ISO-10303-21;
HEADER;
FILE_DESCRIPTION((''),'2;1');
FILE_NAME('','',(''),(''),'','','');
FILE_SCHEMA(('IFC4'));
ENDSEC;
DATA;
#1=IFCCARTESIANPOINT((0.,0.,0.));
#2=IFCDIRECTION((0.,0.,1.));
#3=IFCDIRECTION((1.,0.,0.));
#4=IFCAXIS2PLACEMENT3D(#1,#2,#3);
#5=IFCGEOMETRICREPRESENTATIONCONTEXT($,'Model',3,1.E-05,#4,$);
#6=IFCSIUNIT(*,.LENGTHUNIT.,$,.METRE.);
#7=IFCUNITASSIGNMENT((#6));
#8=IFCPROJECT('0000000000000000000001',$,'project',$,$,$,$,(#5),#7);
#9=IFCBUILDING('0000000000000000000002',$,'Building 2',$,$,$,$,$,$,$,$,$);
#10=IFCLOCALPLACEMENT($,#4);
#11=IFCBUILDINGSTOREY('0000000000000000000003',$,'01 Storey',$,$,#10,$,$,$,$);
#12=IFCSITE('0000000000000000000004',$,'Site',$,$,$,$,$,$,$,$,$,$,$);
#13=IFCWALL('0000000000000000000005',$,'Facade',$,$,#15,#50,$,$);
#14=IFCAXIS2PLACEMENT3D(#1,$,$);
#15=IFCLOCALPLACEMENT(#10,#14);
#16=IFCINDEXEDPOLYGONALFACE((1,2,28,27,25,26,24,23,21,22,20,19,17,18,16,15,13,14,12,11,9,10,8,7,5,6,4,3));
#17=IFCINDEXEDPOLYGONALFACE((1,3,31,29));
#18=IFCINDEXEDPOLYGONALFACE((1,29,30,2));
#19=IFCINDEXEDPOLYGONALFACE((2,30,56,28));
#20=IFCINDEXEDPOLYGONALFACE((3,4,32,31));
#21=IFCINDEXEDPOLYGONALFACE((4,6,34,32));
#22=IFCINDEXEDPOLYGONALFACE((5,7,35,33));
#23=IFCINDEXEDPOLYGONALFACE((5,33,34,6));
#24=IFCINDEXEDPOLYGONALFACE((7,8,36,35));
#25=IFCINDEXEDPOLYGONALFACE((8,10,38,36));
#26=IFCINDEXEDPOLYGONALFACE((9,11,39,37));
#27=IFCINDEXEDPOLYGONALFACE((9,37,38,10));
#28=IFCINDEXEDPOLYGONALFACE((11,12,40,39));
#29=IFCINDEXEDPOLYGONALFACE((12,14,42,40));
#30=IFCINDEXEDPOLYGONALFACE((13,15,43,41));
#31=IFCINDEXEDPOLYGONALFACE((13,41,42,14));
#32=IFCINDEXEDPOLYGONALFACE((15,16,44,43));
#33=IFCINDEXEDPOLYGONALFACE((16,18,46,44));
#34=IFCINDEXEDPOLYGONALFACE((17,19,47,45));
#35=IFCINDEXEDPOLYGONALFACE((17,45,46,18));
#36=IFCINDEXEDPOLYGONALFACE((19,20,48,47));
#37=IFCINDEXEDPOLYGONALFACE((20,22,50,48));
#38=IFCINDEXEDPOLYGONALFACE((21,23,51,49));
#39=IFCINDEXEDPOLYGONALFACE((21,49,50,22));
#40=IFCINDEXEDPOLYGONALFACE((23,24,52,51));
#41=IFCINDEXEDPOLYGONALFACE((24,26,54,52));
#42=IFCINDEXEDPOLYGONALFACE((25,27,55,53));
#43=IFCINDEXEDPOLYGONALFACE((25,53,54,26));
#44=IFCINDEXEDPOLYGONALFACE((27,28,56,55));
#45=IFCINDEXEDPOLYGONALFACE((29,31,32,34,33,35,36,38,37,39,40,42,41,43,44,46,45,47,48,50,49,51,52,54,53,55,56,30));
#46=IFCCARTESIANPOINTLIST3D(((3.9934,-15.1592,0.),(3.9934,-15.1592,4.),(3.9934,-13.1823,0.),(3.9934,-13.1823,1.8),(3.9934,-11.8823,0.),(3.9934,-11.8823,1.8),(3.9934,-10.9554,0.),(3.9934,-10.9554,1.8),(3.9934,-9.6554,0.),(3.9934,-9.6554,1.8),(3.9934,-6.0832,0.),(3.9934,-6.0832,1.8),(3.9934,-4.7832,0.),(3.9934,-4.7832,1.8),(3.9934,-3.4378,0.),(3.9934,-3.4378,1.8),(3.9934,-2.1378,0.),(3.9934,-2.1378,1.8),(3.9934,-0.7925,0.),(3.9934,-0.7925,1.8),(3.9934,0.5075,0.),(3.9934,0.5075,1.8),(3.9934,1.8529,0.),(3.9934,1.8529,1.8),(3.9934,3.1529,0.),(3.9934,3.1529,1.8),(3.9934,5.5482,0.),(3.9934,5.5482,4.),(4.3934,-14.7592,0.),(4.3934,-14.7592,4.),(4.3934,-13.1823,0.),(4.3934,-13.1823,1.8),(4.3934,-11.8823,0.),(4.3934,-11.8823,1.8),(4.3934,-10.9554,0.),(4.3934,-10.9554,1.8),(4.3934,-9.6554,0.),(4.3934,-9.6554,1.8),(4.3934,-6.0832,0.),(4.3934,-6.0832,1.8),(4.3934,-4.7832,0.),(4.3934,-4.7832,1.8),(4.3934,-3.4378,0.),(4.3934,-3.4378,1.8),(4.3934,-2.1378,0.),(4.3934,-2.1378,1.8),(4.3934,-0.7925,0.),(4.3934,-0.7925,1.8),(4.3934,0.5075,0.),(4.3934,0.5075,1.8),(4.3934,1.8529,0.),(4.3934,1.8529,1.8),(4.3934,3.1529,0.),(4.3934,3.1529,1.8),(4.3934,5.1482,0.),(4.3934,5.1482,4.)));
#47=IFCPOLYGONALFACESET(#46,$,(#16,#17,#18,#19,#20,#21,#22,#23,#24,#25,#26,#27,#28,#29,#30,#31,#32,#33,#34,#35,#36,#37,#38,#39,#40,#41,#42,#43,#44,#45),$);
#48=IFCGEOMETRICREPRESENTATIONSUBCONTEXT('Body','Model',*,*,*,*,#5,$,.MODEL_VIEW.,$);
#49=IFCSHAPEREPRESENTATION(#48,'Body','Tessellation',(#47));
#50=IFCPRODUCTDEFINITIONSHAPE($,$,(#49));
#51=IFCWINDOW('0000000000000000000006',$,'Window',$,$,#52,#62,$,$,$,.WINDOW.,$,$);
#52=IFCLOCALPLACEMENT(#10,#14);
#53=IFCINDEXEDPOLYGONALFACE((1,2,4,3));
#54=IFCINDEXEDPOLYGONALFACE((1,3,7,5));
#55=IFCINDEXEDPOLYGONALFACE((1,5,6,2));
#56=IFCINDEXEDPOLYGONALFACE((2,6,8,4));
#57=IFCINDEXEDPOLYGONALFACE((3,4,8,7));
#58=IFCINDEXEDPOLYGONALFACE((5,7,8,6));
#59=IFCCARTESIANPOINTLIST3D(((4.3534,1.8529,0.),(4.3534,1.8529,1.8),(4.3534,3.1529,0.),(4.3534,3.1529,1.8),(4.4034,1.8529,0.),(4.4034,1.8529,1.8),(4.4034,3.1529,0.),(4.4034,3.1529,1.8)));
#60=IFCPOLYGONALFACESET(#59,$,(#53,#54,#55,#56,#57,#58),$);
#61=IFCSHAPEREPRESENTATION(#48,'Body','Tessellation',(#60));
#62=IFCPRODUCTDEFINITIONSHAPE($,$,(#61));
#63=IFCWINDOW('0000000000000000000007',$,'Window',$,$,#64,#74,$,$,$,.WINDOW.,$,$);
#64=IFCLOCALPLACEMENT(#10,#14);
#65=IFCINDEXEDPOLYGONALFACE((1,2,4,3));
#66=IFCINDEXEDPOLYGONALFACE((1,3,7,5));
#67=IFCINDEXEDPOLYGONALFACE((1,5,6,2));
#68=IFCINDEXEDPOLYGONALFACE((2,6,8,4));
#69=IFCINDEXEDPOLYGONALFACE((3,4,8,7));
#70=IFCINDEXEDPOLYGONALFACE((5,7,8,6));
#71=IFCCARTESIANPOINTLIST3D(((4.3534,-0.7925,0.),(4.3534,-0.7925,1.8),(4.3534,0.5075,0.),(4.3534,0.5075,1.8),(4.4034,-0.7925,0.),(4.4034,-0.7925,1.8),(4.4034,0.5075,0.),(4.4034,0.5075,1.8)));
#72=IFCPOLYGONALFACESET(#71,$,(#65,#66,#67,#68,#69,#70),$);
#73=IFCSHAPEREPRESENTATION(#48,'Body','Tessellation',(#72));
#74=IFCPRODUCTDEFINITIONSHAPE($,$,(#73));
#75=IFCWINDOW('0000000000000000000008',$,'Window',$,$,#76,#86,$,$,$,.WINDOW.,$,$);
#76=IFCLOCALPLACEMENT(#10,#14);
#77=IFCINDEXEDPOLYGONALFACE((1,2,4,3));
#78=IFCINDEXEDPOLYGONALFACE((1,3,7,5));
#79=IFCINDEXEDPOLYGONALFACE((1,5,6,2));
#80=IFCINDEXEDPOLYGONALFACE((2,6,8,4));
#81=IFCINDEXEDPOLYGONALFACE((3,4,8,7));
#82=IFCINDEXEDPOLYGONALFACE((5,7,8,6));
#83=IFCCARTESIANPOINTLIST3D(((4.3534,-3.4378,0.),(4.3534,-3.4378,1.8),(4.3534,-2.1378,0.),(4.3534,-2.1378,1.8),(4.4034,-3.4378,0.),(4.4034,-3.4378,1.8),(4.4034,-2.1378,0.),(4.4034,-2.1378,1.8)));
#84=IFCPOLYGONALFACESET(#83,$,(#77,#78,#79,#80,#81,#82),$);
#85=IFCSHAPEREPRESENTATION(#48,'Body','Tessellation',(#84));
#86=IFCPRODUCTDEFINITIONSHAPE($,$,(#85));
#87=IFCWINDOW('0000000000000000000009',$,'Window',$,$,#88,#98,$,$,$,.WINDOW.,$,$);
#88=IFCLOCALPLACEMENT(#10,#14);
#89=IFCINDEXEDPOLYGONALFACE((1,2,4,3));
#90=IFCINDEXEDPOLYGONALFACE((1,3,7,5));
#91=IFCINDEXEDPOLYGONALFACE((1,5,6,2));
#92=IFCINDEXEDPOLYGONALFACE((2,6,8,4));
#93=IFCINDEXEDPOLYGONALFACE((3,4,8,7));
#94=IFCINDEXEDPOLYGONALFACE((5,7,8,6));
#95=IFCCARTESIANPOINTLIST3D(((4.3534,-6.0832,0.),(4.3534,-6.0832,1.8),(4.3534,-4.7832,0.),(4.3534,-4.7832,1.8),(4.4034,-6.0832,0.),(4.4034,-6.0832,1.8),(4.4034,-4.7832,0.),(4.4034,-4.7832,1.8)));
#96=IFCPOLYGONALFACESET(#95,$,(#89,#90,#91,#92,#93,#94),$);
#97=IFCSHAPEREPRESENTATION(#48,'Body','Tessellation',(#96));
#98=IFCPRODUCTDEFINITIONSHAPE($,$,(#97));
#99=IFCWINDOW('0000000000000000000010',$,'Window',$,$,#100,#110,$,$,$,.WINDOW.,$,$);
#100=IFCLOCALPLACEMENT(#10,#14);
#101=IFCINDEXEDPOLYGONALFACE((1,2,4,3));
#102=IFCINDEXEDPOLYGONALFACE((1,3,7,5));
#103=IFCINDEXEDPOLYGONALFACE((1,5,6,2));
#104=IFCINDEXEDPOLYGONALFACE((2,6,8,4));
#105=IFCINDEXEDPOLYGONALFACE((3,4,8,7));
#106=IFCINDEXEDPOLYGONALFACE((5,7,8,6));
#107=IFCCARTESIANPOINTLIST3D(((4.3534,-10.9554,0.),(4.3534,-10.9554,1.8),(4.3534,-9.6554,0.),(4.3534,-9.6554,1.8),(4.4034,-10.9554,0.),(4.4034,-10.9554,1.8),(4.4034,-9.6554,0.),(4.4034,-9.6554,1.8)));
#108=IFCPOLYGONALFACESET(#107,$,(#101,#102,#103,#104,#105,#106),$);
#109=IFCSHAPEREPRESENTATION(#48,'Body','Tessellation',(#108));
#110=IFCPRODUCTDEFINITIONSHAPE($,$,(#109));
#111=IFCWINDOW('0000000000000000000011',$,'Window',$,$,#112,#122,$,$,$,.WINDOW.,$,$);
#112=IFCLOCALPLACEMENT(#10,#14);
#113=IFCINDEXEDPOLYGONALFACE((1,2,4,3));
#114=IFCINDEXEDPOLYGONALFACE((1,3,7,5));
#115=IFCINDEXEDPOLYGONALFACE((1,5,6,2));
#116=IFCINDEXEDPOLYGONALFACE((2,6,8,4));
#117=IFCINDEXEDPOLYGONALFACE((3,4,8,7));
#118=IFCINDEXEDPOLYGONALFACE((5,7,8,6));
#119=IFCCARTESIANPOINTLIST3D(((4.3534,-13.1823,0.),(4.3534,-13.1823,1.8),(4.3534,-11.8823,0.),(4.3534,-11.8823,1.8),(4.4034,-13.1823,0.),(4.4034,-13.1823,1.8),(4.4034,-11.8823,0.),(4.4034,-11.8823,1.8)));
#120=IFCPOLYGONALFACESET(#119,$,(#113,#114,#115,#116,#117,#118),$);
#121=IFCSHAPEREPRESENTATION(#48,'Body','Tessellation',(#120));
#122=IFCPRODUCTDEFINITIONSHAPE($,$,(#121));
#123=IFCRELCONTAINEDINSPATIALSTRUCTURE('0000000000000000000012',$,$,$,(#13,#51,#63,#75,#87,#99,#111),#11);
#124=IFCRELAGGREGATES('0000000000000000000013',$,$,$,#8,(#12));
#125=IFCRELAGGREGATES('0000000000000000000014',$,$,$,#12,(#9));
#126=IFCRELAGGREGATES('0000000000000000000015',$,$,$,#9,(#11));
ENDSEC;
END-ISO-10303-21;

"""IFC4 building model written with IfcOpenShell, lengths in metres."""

from ifc_helpers import new_model, si_unit, origin_with_axes, place, context, subcontext, project, spatial, line, indexed_curve, outline, extrude, element, fill, save


model = new_model("IFC4")

# Units and contexts
model_context = context("Model", 3, precision=1e-05, world=origin_with_axes())
body_context = subcontext(model_context, "Body", "Model", "MODEL_VIEW")
ifc_project = project(units=[si_unit("LENGTHUNIT", "METRE")], contexts=[model_context])

# Site, building, storey
site = spatial("IfcSite", under=ifc_project, Name="Site")
building = spatial("IfcBuilding", under=site, Name="Building 2")
storey_placement = place(None, origin_with_axes())
storey = spatial("IfcBuildingStorey", under=building, at=storey_placement, Name="01 Storey")

# Wall, openings, windows
wall_1_placement = place(storey_placement, origin_with_axes())
wall_1 = element("IfcWall", 1, at=wall_1_placement, inside=storey, Name="Facade", context=body_context, shape_type="SweptSolid", body=[
    extrude(outline(indexed_curve([(4.3934, 5.1482), (4.3934, -14.7592), (3.9934, -15.1592), (3.9934, 5.5482)], segments=[line(1, 2), line(2, 3), line(3, 4)])), origin_with_axes(), (0.0, 0.0, 1.0), 4.0),
])
opening_1_placement = place(wall_1_placement, origin_with_axes())
opening_1 = element("IfcOpeningElement", 2, at=opening_1_placement, cuts=wall_1, context=body_context, shape_type="SweptSolid", body=[
    extrude(outline(indexed_curve([(3.9534, 3.1529), (4.4534, 3.1529), (4.4534, 1.8529), (3.9534, 1.8529)], segments=[line(1, 2), line(2, 3), line(3, 4)])), origin_with_axes(), (0.0, 0.0, 1.0), 1.8),
])
opening_2_placement = place(wall_1_placement, origin_with_axes())
opening_2 = element("IfcOpeningElement", 3, at=opening_2_placement, cuts=wall_1, context=body_context, shape_type="SweptSolid", body=[
    extrude(outline(indexed_curve([(3.9534, 0.5075), (4.4534, 0.5075), (4.4534, -0.7925), (3.9534, -0.7925)], segments=[line(1, 2), line(2, 3), line(3, 4)])), origin_with_axes(), (0.0, 0.0, 1.0), 1.8),
])
opening_3_placement = place(wall_1_placement, origin_with_axes())
opening_3 = element("IfcOpeningElement", 4, at=opening_3_placement, cuts=wall_1, context=body_context, shape_type="SweptSolid", body=[
    extrude(outline(indexed_curve([(3.9534, -2.1378), (4.4534, -2.1378), (4.4534, -3.4378), (3.9534, -3.4378)], segments=[line(1, 2), line(2, 3), line(3, 4)])), origin_with_axes(), (0.0, 0.0, 1.0), 1.8),
])
opening_4_placement = place(wall_1_placement, origin_with_axes())
opening_4 = element("IfcOpeningElement", 5, at=opening_4_placement, cuts=wall_1, context=body_context, shape_type="SweptSolid", body=[
    extrude(outline(indexed_curve([(3.9534, -4.7832), (4.4534, -4.7832), (4.4534, -6.0832), (3.9534, -6.0832)], segments=[line(1, 2), line(2, 3), line(3, 4)])), origin_with_axes(), (0.0, 0.0, 1.0), 1.8),
])
opening_5_placement = place(wall_1_placement, origin_with_axes())
opening_5 = element("IfcOpeningElement", 6, at=opening_5_placement, cuts=wall_1, context=body_context, shape_type="SweptSolid", body=[
    extrude(outline(indexed_curve([(3.9534, -9.6554), (4.4534, -9.6554), (4.4534, -10.9554), (3.9534, -10.9554)], segments=[line(1, 2), line(2, 3), line(3, 4)])), origin_with_axes(), (0.0, 0.0, 1.0), 1.8),
])
opening_6_placement = place(wall_1_placement, origin_with_axes())
opening_6 = element("IfcOpeningElement", 7, at=opening_6_placement, cuts=wall_1, context=body_context, shape_type="SweptSolid", body=[
    extrude(outline(indexed_curve([(3.9534, -11.8823), (4.4534, -11.8823), (4.4534, -13.1823), (3.9534, -13.1823)], segments=[line(1, 2), line(2, 3), line(3, 4)])), origin_with_axes(), (0.0, 0.0, 1.0), 1.8),
])
window_1_placement = place(storey_placement, origin_with_axes())
window_1 = element("IfcWindow", 8, at=window_1_placement, inside=storey, Name="Window", PredefinedType="WINDOW", context=body_context, shape_type="SweptSolid", body=[
    extrude(outline(indexed_curve([(4.3534, 3.1529), (4.4034, 3.1529), (4.4034, 1.8529), (4.3534, 1.8529)], segments=[line(1, 2), line(2, 3), line(3, 4)])), origin_with_axes(), (0.0, 0.0, 1.0), 1.8),
])
fill(opening_1, window_1)
window_2_placement = place(storey_placement, origin_with_axes())
window_2 = element("IfcWindow", 9, at=window_2_placement, inside=storey, Name="Window", PredefinedType="WINDOW", context=body_context, shape_type="SweptSolid", body=[
    extrude(outline(indexed_curve([(4.3534, 0.5075), (4.4034, 0.5075), (4.4034, -0.7925), (4.3534, -0.7925)], segments=[line(1, 2), line(2, 3), line(3, 4)])), origin_with_axes(), (0.0, 0.0, 1.0), 1.8),
])
fill(opening_2, window_2)
window_3_placement = place(storey_placement, origin_with_axes())
window_3 = element("IfcWindow", 10, at=window_3_placement, inside=storey, Name="Window", PredefinedType="WINDOW", context=body_context, shape_type="SweptSolid", body=[
    extrude(outline(indexed_curve([(4.3534, -2.1378), (4.4034, -2.1378), (4.4034, -3.4378), (4.3534, -3.4378)], segments=[line(1, 2), line(2, 3), line(3, 4)])), origin_with_axes(), (0.0, 0.0, 1.0), 1.8),
])
fill(opening_3, window_3)
window_4_placement = place(storey_placement, origin_with_axes())
window_4 = element("IfcWindow", 11, at=window_4_placement, inside=storey, Name="Window", PredefinedType="WINDOW", context=body_context, shape_type="SweptSolid", body=[
    extrude(outline(indexed_curve([(4.3534, -4.7832), (4.4034, -4.7832), (4.4034, -6.0832), (4.3534, -6.0832)], segments=[line(1, 2), line(2, 3), line(3, 4)])), origin_with_axes(), (0.0, 0.0, 1.0), 1.8),
])
fill(opening_4, window_4)
window_5_placement = place(storey_placement, origin_with_axes())
window_5 = element("IfcWindow", 12, at=window_5_placement, inside=storey, Name="Window", PredefinedType="WINDOW", context=body_context, shape_type="SweptSolid", body=[
    extrude(outline(indexed_curve([(4.3534, -9.6554), (4.4034, -9.6554), (4.4034, -10.9554), (4.3534, -10.9554)], segments=[line(1, 2), line(2, 3), line(3, 4)])), origin_with_axes(), (0.0, 0.0, 1.0), 1.8),
])
fill(opening_5, window_5)
window_6_placement = place(storey_placement, origin_with_axes())
window_6 = element("IfcWindow", 13, at=window_6_placement, inside=storey, Name="Window", PredefinedType="WINDOW", context=body_context, shape_type="SweptSolid", body=[
    extrude(outline(indexed_curve([(4.3534, -11.8823), (4.4034, -11.8823), (4.4034, -13.1823), (4.3534, -13.1823)], segments=[line(1, 2), line(2, 3), line(3, 4)])), origin_with_axes(), (0.0, 0.0, 1.0), 1.8),
])
fill(opening_6, window_6)

save(model, "model.ifc")
